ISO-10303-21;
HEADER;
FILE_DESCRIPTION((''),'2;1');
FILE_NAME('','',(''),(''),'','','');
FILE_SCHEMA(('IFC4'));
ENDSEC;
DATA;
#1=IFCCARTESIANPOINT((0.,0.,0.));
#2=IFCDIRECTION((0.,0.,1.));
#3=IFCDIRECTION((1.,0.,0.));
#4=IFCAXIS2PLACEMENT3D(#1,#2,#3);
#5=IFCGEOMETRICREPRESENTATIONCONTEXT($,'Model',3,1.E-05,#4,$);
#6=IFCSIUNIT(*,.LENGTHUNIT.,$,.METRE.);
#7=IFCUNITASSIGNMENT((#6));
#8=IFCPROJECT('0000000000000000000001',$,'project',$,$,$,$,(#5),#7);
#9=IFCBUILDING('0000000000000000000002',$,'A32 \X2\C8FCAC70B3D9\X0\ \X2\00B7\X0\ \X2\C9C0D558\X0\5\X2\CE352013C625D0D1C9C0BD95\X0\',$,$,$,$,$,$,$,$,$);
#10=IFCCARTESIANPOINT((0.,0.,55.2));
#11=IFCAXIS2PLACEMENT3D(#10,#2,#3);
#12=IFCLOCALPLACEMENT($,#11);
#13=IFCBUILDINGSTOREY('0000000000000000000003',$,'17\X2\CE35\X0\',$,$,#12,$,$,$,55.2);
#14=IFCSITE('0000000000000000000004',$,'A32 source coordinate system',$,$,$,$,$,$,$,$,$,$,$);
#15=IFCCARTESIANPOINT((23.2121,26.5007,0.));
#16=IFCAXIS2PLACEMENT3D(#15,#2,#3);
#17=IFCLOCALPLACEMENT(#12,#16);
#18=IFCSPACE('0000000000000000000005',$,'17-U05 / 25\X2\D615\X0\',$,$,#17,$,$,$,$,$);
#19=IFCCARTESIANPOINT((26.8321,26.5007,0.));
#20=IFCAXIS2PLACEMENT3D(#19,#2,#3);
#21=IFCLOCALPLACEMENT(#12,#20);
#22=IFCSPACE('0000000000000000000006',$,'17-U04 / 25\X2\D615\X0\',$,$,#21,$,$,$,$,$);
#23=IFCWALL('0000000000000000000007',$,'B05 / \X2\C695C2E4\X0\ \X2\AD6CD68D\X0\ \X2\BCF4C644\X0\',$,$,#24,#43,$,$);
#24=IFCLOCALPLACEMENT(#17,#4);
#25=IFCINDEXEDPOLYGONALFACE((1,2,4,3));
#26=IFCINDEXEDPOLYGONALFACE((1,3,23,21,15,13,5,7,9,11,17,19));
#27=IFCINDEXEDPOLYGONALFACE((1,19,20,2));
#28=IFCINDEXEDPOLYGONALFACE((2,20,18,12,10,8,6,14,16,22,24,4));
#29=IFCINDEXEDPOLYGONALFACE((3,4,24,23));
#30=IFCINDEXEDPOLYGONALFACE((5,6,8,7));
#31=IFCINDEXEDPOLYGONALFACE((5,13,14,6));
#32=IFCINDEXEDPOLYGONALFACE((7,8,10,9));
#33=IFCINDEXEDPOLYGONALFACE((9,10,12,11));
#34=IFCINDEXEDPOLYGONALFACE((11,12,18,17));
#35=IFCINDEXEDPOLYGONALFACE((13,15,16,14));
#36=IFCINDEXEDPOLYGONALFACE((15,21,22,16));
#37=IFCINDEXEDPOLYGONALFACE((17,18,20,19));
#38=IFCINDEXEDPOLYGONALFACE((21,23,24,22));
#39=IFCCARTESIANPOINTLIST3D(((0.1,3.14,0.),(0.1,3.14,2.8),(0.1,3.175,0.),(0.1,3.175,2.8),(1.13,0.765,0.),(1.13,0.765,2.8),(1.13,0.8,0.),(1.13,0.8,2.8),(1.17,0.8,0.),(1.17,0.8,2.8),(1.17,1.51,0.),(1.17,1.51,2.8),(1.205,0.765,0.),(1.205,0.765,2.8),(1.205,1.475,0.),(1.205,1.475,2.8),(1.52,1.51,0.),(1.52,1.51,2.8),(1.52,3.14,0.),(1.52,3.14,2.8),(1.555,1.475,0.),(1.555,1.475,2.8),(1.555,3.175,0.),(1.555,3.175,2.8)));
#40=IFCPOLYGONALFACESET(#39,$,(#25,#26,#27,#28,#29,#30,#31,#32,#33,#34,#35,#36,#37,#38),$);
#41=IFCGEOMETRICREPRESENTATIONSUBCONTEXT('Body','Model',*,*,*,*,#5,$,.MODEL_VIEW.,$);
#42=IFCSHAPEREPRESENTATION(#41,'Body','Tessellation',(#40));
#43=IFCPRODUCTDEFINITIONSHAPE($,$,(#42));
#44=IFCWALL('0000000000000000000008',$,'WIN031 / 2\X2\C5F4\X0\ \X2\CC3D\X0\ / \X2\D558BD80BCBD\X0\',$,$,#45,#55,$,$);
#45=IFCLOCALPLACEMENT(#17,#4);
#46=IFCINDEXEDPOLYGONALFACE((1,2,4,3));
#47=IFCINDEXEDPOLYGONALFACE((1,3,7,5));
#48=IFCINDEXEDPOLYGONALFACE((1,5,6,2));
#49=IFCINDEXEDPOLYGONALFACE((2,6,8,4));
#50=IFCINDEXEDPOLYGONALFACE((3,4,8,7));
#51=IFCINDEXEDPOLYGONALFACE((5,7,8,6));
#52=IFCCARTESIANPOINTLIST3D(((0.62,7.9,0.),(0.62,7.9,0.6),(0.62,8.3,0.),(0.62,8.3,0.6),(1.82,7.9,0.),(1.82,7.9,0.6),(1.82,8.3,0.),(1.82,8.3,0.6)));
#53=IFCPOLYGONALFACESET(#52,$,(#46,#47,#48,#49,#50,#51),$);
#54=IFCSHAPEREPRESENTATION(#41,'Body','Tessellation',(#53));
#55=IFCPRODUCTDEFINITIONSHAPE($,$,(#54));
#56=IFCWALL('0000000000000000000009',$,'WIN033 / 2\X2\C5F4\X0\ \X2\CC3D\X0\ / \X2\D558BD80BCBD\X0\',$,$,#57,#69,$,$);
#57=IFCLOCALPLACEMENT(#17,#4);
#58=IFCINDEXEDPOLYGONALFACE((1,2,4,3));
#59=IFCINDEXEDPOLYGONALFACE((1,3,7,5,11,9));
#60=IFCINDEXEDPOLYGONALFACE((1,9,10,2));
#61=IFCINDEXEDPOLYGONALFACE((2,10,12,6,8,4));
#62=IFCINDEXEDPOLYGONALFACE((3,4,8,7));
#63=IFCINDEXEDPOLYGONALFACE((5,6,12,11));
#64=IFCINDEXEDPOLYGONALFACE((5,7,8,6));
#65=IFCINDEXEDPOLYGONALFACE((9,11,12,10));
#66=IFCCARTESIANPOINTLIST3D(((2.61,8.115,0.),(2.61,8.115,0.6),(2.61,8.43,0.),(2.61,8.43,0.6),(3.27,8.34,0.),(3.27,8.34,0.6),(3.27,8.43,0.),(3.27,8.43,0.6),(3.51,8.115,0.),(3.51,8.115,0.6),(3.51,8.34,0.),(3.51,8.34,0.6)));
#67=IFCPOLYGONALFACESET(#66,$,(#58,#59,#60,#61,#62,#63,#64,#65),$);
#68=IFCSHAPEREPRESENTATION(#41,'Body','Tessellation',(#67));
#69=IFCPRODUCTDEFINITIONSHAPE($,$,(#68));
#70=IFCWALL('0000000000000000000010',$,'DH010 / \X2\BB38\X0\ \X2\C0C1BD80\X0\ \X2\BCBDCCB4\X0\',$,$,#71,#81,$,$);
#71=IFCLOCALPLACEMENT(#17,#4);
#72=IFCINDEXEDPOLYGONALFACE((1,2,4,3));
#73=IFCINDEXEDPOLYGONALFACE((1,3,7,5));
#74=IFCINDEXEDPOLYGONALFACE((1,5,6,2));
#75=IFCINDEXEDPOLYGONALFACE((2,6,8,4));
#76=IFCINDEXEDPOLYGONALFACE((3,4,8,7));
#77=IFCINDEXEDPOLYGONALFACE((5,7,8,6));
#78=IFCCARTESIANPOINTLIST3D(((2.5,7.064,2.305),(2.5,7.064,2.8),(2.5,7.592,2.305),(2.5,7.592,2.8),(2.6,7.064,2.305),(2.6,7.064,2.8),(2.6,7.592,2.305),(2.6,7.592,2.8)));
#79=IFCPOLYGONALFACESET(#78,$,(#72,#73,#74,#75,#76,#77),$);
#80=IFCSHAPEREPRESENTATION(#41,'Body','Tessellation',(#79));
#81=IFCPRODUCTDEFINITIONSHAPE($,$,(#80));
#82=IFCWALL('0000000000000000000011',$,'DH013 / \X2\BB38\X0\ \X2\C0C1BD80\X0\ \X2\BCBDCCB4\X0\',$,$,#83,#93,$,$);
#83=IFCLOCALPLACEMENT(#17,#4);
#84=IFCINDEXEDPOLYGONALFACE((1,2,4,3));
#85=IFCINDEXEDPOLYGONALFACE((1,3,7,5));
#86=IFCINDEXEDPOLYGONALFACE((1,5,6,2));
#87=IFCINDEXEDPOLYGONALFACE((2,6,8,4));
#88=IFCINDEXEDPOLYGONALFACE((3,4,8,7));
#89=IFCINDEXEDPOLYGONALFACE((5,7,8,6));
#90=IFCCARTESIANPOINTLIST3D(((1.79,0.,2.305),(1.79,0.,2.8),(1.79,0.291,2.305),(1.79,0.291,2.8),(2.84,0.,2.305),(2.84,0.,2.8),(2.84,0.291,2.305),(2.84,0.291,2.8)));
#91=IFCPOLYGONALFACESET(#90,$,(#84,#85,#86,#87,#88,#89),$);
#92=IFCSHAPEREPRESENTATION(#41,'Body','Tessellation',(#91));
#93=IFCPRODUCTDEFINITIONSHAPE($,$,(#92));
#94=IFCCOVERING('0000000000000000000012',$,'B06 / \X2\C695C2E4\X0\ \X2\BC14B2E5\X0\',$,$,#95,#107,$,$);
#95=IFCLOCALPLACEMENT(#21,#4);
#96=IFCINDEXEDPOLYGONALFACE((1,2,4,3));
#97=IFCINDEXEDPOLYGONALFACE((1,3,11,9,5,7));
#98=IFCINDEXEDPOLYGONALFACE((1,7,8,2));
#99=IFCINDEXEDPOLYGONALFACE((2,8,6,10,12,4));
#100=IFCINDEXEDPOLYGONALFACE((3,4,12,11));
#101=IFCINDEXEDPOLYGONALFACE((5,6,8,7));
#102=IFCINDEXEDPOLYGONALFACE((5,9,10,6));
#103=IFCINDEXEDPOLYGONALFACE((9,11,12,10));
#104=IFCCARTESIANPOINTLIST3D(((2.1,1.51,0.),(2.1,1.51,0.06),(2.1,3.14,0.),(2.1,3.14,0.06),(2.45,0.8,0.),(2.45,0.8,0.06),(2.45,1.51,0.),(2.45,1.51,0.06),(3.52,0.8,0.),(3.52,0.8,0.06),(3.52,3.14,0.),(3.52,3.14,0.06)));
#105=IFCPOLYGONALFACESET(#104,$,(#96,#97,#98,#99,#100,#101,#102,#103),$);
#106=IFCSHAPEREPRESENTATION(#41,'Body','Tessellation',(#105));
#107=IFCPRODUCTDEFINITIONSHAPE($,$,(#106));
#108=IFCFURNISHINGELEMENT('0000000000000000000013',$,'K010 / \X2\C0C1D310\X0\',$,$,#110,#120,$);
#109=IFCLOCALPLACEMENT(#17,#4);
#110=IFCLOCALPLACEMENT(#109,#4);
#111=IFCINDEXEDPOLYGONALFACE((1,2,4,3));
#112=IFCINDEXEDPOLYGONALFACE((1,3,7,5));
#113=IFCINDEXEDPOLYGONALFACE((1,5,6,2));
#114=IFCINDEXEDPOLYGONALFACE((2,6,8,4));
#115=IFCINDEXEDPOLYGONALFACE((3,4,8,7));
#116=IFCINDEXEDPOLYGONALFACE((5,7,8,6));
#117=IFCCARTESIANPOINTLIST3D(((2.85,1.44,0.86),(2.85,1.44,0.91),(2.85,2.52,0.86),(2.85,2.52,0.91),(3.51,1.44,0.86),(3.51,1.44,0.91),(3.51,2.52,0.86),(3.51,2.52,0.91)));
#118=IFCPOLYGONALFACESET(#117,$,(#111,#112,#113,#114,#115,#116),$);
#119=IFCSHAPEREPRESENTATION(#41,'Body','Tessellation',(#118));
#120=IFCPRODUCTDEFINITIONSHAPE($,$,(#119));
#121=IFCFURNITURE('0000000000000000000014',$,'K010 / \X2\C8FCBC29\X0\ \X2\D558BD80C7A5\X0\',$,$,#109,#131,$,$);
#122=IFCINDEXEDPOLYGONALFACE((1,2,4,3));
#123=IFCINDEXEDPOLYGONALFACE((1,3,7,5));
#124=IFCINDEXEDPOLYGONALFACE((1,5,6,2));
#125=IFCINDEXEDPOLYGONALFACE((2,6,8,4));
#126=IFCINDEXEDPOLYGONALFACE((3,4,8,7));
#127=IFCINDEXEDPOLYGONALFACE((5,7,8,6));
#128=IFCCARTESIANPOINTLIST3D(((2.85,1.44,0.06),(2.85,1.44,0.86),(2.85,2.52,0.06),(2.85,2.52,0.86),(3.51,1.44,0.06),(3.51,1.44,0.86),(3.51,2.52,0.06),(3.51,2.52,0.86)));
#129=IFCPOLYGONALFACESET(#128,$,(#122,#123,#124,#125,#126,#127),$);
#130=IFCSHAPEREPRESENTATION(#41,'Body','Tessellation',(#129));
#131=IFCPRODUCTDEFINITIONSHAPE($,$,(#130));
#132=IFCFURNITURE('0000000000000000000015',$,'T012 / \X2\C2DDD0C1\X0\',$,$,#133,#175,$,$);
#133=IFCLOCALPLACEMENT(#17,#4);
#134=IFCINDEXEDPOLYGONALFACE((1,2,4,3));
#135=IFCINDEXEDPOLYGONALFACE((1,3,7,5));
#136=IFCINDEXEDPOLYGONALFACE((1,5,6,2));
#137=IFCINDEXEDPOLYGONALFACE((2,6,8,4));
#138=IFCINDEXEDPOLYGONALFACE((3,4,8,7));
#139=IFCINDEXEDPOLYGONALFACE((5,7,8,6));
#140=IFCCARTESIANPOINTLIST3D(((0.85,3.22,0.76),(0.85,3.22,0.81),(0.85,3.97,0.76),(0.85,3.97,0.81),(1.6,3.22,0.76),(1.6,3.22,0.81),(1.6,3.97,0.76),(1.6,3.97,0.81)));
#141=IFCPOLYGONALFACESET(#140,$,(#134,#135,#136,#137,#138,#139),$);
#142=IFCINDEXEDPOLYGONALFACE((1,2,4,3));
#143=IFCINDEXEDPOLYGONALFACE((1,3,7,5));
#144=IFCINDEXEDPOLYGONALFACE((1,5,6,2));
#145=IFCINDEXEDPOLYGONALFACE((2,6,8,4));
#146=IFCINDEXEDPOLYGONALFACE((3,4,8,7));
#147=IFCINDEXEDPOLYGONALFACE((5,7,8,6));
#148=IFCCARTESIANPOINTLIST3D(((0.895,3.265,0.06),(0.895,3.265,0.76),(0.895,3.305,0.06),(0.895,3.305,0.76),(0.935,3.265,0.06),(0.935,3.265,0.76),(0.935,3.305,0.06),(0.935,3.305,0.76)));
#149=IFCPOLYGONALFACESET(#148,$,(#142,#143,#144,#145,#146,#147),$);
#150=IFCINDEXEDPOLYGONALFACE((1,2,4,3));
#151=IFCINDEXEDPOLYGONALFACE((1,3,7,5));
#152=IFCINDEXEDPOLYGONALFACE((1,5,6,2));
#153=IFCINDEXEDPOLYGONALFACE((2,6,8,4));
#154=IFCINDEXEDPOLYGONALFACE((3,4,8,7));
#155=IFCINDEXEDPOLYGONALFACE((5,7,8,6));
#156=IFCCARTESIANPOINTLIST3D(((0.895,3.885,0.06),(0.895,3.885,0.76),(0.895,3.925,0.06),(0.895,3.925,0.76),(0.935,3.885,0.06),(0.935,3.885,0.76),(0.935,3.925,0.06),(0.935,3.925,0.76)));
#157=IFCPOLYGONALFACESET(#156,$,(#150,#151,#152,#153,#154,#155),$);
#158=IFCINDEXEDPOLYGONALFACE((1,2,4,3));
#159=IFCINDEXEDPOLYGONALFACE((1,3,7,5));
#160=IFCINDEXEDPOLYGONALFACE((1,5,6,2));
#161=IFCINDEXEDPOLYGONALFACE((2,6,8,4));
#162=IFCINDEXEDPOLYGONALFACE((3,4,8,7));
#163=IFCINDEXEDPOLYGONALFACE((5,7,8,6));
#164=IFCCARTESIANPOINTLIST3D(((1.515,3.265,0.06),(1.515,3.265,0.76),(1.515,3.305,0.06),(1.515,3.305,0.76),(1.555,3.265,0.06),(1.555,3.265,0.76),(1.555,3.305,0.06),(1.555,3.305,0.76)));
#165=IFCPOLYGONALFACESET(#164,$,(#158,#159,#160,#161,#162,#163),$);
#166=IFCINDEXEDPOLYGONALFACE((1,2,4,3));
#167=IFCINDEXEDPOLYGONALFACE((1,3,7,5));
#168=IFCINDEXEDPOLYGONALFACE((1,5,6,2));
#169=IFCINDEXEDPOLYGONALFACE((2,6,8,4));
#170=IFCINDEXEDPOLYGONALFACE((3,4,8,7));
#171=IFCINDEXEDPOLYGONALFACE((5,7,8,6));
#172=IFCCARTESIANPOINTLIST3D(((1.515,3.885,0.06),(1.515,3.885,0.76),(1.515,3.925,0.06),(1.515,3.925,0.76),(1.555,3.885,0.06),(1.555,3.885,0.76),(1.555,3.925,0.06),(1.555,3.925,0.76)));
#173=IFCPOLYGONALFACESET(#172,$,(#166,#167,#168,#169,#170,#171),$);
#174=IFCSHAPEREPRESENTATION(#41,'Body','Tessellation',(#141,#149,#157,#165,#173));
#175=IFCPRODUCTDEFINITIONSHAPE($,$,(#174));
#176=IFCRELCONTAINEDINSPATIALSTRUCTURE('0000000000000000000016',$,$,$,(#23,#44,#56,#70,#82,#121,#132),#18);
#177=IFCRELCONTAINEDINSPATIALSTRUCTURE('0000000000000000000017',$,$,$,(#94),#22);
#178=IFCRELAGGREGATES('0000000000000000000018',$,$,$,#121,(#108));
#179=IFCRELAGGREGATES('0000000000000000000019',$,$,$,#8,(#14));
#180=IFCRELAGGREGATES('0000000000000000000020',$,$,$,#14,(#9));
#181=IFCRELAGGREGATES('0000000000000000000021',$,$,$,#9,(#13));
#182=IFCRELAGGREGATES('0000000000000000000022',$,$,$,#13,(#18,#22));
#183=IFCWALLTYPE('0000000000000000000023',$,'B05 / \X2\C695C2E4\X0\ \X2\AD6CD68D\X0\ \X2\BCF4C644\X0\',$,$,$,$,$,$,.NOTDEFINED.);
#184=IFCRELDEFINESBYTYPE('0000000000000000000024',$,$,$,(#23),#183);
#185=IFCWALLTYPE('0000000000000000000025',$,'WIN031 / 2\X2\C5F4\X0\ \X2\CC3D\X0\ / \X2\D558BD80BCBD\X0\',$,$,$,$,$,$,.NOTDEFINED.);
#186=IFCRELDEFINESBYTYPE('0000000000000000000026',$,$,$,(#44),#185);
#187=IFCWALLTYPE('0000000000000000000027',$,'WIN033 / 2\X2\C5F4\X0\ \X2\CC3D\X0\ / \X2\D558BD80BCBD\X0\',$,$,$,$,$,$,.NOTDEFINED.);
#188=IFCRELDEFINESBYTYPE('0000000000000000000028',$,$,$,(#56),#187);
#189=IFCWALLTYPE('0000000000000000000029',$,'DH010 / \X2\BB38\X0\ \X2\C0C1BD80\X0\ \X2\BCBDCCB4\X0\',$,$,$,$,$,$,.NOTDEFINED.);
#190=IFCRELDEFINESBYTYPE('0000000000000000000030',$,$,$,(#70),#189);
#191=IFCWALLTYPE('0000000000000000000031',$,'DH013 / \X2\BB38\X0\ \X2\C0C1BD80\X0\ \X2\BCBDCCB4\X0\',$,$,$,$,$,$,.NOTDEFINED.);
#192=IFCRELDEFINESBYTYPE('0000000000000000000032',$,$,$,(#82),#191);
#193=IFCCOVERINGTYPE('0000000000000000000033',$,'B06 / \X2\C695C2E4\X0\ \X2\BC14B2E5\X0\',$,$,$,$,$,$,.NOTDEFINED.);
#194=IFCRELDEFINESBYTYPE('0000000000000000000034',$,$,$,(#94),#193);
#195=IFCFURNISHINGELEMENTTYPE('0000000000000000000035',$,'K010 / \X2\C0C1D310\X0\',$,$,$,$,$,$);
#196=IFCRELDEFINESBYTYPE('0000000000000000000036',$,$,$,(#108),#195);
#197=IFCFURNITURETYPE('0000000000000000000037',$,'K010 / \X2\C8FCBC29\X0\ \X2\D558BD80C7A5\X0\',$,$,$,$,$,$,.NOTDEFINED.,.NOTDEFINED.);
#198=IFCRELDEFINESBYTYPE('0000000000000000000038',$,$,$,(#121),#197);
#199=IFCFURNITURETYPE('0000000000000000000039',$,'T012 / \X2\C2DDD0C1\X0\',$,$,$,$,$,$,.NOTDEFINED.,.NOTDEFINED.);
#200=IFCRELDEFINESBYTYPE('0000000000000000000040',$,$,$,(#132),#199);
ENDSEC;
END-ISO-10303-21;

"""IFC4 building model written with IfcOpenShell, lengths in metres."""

from ifc_helpers import new_model, si_unit, frame, origin, origin_with_axes, place, context, subcontext, project, spatial, polyline, outline, extrude, source, transform, mapped, type_object, type_shapes, element, aggregate, save


model = new_model("IFC4")

# Units and contexts
model_context = context("Model", 3, precision=1e-05, world=origin_with_axes())
body_context = subcontext(model_context, "Body", "Model", "MODEL_VIEW")
ifc_project = project(units=[si_unit("LENGTHUNIT", "METRE")], contexts=[model_context])

# Site, building, storey, space
site = spatial("IfcSite", under=ifc_project, Name="A32 source coordinate system")
building = spatial("IfcBuilding", under=site, Name="A32 주거동 · 지하5층–옥탑지붕")
storey_placement = place(None, frame((0.0, 0.0, 55.2), z_axis=(0.0, 0.0, 1.0), x_axis=(1.0, 0.0, 0.0)))
storey = spatial("IfcBuildingStorey", under=building, at=storey_placement, Name="17층", Elevation=55.2)
space_1_placement = place(storey_placement, frame((23.2121, 26.5007, 0.0), z_axis=(0.0, 0.0, 1.0), x_axis=(1.0, 0.0, 0.0)))
space_1 = spatial("IfcSpace", under=storey, at=space_1_placement, Name="17-U05 / 25형")

# Walls
wall_type_1 = type_object("IfcWallType", Name="B05 / 욕실 구획 보완", PredefinedType="NOTDEFINED")
shared_shape_1 = source(origin(), body_context, "Body", "SweptSolid", [
    extrude(outline(polyline([(1.17, 1.51), (1.52, 1.51), (1.52, 3.14), (0.1, 3.14), (0.1, 3.175), (1.555, 3.175), (1.555, 1.475), (1.205, 1.475), (1.205, 0.765), (1.13, 0.765), (1.13, 0.8), (1.17, 0.8), (1.17, 1.51)])), origin(), (0.0, 0.0, 1.0), 2.8),
])
type_shapes(wall_type_1, [shared_shape_1])
wall_1_placement = place(space_1_placement, origin_with_axes())
element("IfcWall", 1, at=wall_1_placement, inside=space_1, type_object=wall_type_1, Name="B05 / 욕실 구획 보완", context=body_context, shape_type="MappedRepresentation", body=[
    mapped(shared_shape_1, transform((0.0, 0.0, 0.0), scale=1.0)),
])
wall_type_2 = type_object("IfcWallType", Name="WIN031 / 2열 창 / 하부벽", PredefinedType="NOTDEFINED")
shared_shape_2 = source(origin(), body_context, "Body", "SweptSolid", [
    extrude(outline(polyline([(0.62, 8.3), (1.82, 8.3), (1.82, 7.9), (0.62, 7.9), (0.62, 8.3)])), origin(), (0.0, 0.0, 1.0), 0.6),
])
type_shapes(wall_type_2, [shared_shape_2])
wall_2_placement = place(space_1_placement, origin_with_axes())
element("IfcWall", 2, at=wall_2_placement, inside=space_1, type_object=wall_type_2, Name="WIN031 / 2열 창 / 하부벽", context=body_context, shape_type="MappedRepresentation", body=[
    mapped(shared_shape_2, transform((0.0, 0.0, 0.0), scale=1.0)),
])
wall_type_3 = type_object("IfcWallType", Name="WIN033 / 2열 창 / 하부벽", PredefinedType="NOTDEFINED")
shared_shape_3 = source(origin(), body_context, "Body", "SweptSolid", [
    extrude(outline(polyline([(2.61, 8.43), (3.27, 8.43), (3.27, 8.34), (3.51, 8.34), (3.51, 8.115), (2.61, 8.115), (2.61, 8.43)])), origin(), (0.0, 0.0, 1.0), 0.6),
])
type_shapes(wall_type_3, [shared_shape_3])
wall_3_placement = place(space_1_placement, origin_with_axes())
element("IfcWall", 3, at=wall_3_placement, inside=space_1, type_object=wall_type_3, Name="WIN033 / 2열 창 / 하부벽", context=body_context, shape_type="MappedRepresentation", body=[
    mapped(shared_shape_3, transform((0.0, 0.0, 0.0), scale=1.0)),
])
wall_type_4 = type_object("IfcWallType", Name="DH010 / 문 상부 벽체", PredefinedType="NOTDEFINED")
shared_shape_4 = source(origin(), body_context, "Body", "SweptSolid", [
    extrude(outline(polyline([(2.5, 7.592), (2.6, 7.592), (2.6, 7.064), (2.5, 7.064), (2.5, 7.592)])), frame((0.0, 0.0, 2.305)), (0.0, 0.0, 1.0), 0.495),
])
type_shapes(wall_type_4, [shared_shape_4])
wall_4_placement = place(space_1_placement, origin_with_axes())
element("IfcWall", 4, at=wall_4_placement, inside=space_1, type_object=wall_type_4, Name="DH010 / 문 상부 벽체", context=body_context, shape_type="MappedRepresentation", body=[
    mapped(shared_shape_4, transform((0.0, 0.0, 0.0), scale=1.0)),
])
wall_type_5 = type_object("IfcWallType", Name="DH013 / 문 상부 벽체", PredefinedType="NOTDEFINED")
shared_shape_5 = source(origin(), body_context, "Body", "SweptSolid", [
    extrude(outline(polyline([(2.84, 0.291), (2.84, 0.0), (1.79, 0.0), (1.79, 0.291), (2.84, 0.291)])), frame((0.0, 0.0, 2.305)), (0.0, 0.0, 1.0), 0.495),
])
type_shapes(wall_type_5, [shared_shape_5])
wall_5_placement = place(space_1_placement, origin_with_axes())
element("IfcWall", 5, at=wall_5_placement, inside=space_1, type_object=wall_type_5, Name="DH013 / 문 상부 벽체", context=body_context, shape_type="MappedRepresentation", body=[
    mapped(shared_shape_5, transform((0.0, 0.0, 0.0), scale=1.0)),
])

# Shared definitions
space_2_placement = place(storey_placement, frame((26.8321, 26.5007, 0.0), z_axis=(0.0, 0.0, 1.0), x_axis=(1.0, 0.0, 0.0)))
space_2 = spatial("IfcSpace", under=storey, at=space_2_placement, Name="17-U04 / 25형")

# Covering
covering_type = type_object("IfcCoveringType", Name="B06 / 욕실 바닥", PredefinedType="NOTDEFINED")
shared_shape_6 = source(origin(), body_context, "Body", "SweptSolid", [
    extrude(outline(polyline([(2.1, 3.14), (3.52, 3.14), (3.52, 0.8), (2.45, 0.8), (2.45, 1.51), (2.1, 1.51), (2.1, 3.14)])), origin(), (0.0, 0.0, 1.0), 0.06),
])
type_shapes(covering_type, [shared_shape_6])
covering_placement = place(space_2_placement, origin_with_axes())
element("IfcCovering", 6, at=covering_placement, inside=space_2, type_object=covering_type, Name="B06 / 욕실 바닥", context=body_context, shape_type="MappedRepresentation", body=[
    mapped(shared_shape_6, transform((0.0, 0.0, 0.0), scale=1.0)),
])

# Furnishing element
furnishing_element_type_1 = type_object("IfcFurnishingElementType", Name="K010 / 상판")
shared_shape_7 = source(origin(), body_context, "Body", "SweptSolid", [
    extrude(outline(polyline([(2.85, 2.52), (3.51, 2.52), (3.51, 1.44), (2.85, 1.44), (2.85, 2.52)])), frame((0.0, 0.0, 0.86)), (0.0, 0.0, 1.0), 0.05),
])
type_shapes(furnishing_element_type_1, [shared_shape_7])
furniture_1_placement = place(space_1_placement, origin_with_axes())
furnishing_1_placement = place(furniture_1_placement, origin_with_axes())
furnishing_1 = element("IfcFurnishingElement", 7, at=furnishing_1_placement, type_object=furnishing_element_type_1, Name="K010 / 상판", context=body_context, shape_type="MappedRepresentation", body=[
    mapped(shared_shape_7, transform((0.0, 0.0, 0.0), scale=1.0)),
])

# Furniture
furniture_type_1 = type_object("IfcFurnitureType", Name="K010 / 주방 하부장", AssemblyPlace="NOTDEFINED", PredefinedType="NOTDEFINED")
shared_shape_8 = source(origin(), body_context, "Body", "SweptSolid", [
    extrude(outline(polyline([(2.85, 1.44), (2.85, 2.52), (3.51, 2.52), (3.51, 1.44), (2.85, 1.44)])), frame((0.0, 0.0, 0.06)), (0.0, 0.0, 1.0), 0.8),
])
type_shapes(furniture_type_1, [shared_shape_8])
furniture_1 = element("IfcFurniture", 8, at=furniture_1_placement, inside=space_1, type_object=furniture_type_1, Name="K010 / 주방 하부장", context=body_context, shape_type="MappedRepresentation", body=[
    mapped(shared_shape_8, transform((0.0, 0.0, 0.0), scale=1.0)),
])
aggregate(furniture_1, [furnishing_1])
furniture_type_2 = type_object("IfcFurnitureType", Name="T012 / 식탁", AssemblyPlace="NOTDEFINED", PredefinedType="NOTDEFINED")
shared_shape_9 = source(origin(), body_context, "Body", "SweptSolid", [
    extrude(outline(polyline([(1.6, 3.97), (1.6, 3.22), (0.85, 3.22), (0.85, 3.97), (1.6, 3.97)])), frame((0.0, 0.0, 0.76)), (0.0, 0.0, 1.0), 0.05),
    extrude(outline(polyline([(0.895, 3.265), (0.895, 3.305), (0.935, 3.305), (0.935, 3.265), (0.895, 3.265)])), frame((0.0, 0.0, 0.06)), (0.0, 0.0, 1.0), 0.7),
    extrude(outline(polyline([(0.895, 3.885), (0.895, 3.925), (0.935, 3.925), (0.935, 3.885), (0.895, 3.885)])), frame((0.0, 0.0, 0.06)), (0.0, 0.0, 1.0), 0.7),
    extrude(outline(polyline([(1.515, 3.265), (1.515, 3.305), (1.555, 3.305), (1.555, 3.265), (1.515, 3.265)])), frame((0.0, 0.0, 0.06)), (0.0, 0.0, 1.0), 0.7),
    extrude(outline(polyline([(1.515, 3.885), (1.515, 3.925), (1.555, 3.925), (1.555, 3.885), (1.515, 3.885)])), frame((0.0, 0.0, 0.06)), (0.0, 0.0, 1.0), 0.7),
])
type_shapes(furniture_type_2, [shared_shape_9])
furniture_2_placement = place(space_1_placement, origin_with_axes())
element("IfcFurniture", 9, at=furniture_2_placement, inside=space_1, type_object=furniture_type_2, Name="T012 / 식탁", context=body_context, shape_type="MappedRepresentation", body=[
    mapped(shared_shape_9, transform((0.0, 0.0, 0.0), scale=1.0)),
])

save(model, "model.ifc")
